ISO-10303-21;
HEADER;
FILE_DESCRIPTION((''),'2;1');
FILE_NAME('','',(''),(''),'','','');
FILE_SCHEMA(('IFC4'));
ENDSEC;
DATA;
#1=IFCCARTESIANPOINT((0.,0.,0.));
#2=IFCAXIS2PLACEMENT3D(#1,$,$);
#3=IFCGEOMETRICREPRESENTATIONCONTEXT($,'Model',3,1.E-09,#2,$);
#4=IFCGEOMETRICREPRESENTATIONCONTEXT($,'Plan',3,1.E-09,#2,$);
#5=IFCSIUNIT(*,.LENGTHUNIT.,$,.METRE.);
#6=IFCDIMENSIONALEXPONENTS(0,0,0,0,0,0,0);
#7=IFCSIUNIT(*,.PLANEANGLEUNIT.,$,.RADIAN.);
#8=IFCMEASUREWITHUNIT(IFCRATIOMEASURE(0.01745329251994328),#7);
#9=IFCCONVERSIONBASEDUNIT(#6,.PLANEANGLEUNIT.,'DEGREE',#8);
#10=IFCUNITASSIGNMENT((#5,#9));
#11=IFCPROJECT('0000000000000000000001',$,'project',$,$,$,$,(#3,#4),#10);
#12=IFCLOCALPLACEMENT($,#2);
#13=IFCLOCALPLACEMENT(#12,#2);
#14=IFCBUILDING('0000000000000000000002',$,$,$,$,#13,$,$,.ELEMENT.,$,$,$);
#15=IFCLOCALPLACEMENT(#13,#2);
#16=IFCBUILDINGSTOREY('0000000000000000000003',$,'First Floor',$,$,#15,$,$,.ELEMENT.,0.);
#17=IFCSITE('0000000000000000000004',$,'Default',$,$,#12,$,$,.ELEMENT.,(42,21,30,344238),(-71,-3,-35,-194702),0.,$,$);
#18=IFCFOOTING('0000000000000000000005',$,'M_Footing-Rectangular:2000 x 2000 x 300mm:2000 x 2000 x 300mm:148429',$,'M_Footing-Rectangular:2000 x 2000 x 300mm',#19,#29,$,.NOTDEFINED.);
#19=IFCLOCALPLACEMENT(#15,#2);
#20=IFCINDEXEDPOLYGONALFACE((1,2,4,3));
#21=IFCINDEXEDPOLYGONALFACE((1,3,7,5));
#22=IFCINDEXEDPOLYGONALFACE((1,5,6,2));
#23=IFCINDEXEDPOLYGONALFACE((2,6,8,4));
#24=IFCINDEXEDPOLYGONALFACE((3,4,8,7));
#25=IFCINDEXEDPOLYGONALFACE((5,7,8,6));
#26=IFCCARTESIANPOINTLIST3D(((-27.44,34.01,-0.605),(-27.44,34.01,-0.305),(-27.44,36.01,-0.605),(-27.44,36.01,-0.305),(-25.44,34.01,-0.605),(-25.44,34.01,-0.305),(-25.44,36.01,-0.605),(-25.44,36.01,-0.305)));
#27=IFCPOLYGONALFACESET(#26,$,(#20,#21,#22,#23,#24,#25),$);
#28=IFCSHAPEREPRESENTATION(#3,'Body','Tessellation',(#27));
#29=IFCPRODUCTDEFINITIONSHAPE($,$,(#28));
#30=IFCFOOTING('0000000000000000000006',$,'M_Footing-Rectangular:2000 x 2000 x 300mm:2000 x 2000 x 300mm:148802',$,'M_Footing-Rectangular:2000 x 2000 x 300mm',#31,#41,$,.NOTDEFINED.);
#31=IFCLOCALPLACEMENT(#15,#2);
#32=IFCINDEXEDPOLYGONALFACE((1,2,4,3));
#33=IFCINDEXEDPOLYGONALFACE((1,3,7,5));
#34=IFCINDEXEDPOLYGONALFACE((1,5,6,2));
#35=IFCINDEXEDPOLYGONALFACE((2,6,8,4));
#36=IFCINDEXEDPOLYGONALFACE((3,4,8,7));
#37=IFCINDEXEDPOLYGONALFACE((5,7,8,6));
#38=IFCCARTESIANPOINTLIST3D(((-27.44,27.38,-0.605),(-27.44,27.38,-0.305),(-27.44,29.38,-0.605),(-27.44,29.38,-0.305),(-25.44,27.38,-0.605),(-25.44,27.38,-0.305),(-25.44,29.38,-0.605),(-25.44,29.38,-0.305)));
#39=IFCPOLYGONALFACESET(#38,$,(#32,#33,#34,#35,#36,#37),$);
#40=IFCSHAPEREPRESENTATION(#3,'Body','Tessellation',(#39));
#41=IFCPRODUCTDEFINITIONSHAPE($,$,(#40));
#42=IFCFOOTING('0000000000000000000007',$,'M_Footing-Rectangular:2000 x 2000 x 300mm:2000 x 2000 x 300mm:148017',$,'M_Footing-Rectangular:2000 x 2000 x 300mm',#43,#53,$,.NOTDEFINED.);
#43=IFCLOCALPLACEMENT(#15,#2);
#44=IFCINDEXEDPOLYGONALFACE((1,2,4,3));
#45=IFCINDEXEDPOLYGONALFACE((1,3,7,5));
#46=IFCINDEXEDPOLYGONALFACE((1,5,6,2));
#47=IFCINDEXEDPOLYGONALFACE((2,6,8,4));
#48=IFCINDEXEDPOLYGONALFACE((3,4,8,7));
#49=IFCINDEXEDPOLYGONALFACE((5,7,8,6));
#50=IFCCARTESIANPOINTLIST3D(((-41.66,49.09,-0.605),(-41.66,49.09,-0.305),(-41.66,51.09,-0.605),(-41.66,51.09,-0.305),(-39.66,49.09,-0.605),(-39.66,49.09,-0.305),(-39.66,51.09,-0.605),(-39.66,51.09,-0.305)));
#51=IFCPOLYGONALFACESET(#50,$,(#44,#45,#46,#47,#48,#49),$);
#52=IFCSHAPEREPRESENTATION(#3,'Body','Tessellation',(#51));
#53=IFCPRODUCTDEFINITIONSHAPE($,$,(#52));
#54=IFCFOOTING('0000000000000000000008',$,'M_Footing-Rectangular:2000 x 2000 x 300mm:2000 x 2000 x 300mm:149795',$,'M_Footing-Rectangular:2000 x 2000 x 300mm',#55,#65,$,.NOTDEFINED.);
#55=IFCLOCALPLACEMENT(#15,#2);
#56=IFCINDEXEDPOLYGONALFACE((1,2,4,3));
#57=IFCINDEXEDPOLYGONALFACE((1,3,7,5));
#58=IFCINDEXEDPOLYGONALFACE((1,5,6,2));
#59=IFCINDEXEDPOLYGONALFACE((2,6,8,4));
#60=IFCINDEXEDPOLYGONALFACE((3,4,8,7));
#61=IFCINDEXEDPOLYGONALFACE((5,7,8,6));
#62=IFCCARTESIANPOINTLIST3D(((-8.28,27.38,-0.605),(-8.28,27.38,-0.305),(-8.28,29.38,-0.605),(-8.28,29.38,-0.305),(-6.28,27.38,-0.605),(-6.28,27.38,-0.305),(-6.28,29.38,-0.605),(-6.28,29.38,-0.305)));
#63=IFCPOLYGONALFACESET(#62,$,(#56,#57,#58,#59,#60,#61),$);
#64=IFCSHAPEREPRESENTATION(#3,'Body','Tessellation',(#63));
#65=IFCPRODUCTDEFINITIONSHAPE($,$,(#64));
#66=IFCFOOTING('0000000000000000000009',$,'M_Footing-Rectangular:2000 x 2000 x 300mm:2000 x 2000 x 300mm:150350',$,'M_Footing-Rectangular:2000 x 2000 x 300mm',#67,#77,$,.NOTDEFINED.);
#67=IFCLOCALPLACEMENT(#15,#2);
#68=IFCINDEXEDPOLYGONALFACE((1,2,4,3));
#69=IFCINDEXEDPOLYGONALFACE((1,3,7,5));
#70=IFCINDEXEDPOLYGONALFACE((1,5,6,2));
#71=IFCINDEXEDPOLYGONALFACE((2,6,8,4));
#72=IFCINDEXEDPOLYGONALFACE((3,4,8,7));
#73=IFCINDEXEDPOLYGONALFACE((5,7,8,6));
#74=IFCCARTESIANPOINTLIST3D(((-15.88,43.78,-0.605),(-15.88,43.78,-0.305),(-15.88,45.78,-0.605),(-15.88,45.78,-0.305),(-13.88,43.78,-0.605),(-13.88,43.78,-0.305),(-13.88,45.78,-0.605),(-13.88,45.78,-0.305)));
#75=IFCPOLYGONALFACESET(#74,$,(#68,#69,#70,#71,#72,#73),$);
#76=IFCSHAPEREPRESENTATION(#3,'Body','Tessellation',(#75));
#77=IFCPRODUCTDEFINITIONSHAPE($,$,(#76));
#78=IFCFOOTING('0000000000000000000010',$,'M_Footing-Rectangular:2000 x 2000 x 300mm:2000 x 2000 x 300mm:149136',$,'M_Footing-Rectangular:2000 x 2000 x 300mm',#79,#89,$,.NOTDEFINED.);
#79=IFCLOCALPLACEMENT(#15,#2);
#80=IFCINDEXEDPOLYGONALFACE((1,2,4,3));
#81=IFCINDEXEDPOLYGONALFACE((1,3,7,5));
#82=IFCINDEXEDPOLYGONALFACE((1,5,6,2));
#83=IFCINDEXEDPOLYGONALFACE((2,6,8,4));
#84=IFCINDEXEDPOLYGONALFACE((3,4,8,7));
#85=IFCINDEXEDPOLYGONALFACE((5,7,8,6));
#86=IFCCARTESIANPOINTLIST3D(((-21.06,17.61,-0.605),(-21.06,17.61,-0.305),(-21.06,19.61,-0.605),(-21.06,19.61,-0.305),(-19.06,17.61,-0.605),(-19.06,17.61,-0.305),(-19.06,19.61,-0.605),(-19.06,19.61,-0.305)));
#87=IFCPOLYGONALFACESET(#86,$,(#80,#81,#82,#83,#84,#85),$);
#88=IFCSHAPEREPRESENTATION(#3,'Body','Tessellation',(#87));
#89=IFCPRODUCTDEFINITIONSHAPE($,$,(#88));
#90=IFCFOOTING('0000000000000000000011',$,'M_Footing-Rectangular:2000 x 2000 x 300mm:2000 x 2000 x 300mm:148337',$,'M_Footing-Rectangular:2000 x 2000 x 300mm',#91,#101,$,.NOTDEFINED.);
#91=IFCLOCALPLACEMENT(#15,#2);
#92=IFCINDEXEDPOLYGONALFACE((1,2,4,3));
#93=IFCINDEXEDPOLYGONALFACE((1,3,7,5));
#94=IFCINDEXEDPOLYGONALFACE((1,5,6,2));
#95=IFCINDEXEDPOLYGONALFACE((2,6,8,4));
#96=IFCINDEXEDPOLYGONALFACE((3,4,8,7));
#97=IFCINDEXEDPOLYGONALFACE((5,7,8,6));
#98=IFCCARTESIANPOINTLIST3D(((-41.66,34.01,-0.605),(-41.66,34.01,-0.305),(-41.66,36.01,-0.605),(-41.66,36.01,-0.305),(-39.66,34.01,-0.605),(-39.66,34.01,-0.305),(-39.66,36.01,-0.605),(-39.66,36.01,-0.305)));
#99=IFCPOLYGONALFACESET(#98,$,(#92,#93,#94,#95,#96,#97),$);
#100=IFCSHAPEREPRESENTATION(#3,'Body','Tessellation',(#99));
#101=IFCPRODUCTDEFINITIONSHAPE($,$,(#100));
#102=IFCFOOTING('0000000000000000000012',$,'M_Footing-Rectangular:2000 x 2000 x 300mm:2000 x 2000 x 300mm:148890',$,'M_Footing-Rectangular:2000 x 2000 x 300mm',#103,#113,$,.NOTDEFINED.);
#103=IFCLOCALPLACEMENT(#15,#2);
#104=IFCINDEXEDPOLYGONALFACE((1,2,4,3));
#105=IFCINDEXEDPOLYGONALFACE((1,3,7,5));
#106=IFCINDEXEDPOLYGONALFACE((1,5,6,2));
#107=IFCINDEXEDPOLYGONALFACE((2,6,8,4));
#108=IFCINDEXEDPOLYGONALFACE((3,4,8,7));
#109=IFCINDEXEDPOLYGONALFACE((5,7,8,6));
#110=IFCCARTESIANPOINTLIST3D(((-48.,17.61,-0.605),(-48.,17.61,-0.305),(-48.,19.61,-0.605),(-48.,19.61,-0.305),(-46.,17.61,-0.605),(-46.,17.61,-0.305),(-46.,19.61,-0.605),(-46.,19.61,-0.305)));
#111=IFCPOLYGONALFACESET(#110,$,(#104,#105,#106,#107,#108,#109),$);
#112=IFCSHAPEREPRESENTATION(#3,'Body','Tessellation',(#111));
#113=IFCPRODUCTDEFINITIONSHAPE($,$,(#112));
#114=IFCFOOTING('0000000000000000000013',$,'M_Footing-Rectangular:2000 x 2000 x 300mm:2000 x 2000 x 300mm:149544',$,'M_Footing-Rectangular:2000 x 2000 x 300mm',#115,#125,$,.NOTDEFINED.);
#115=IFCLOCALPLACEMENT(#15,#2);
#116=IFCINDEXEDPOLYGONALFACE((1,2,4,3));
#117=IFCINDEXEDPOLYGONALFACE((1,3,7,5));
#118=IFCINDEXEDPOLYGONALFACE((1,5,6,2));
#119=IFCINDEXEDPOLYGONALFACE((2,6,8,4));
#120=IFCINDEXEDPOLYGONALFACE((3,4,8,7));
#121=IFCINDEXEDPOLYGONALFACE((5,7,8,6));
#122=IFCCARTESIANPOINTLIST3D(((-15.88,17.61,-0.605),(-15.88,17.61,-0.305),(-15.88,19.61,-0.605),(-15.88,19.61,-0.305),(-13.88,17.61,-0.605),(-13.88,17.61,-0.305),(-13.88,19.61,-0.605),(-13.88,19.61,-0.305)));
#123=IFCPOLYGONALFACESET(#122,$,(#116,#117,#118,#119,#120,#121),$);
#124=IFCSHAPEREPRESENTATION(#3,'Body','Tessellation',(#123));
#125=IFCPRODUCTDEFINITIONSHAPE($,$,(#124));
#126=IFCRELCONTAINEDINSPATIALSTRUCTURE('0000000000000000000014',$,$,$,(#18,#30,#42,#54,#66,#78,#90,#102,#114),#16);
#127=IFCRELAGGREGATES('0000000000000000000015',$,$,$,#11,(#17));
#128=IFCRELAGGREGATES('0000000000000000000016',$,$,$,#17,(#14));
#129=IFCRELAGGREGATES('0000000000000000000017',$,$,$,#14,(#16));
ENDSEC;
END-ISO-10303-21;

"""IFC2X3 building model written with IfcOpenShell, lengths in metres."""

from ifc_helpers import new_model, entity, si_unit, converted_unit, frame, origin, origin_2d_with_axis, place, context, project, spatial, rectangle, extrude, element, save


model = new_model("IFC2X3")

# Units and contexts
model_context = context("Model", 3, precision=1e-09, world=origin())
plan_context = context("Plan", 3, precision=1e-09, world=origin())
ifc_project = project(units=[si_unit("LENGTHUNIT", "METRE"), converted_unit("PLANEANGLEUNIT", "DEGREE", entity("IfcRatioMeasure", 0.01745329251994328), si_unit("PLANEANGLEUNIT", "RADIAN"), dimensions=[0, 0, 0, 0, 0, 0, 0])], contexts=[model_context, plan_context])

# Site, building, storey
site_placement = place(None, origin())
site = spatial("IfcSite", under=ifc_project, at=site_placement, Name="Default", CompositionType="ELEMENT", RefLatitude=(42, 21, 30, 344238), RefLongitude=(-71, -3, -35, -194702), RefElevation=0.0)
building_placement = place(site_placement, origin())
building = spatial("IfcBuilding", under=site, at=building_placement, CompositionType="ELEMENT")
storey_placement = place(building_placement, origin())
storey = spatial("IfcBuildingStorey", under=building, at=storey_placement, Name="First Floor", CompositionType="ELEMENT", Elevation=0.0)

# Footings
footing_1_placement = place(storey_placement, origin())
element("IfcFooting", 1, at=footing_1_placement, inside=storey, Name="M_Footing-Rectangular:2000 x 2000 x 300mm:2000 x 2000 x 300mm:148429", ObjectType="M_Footing-Rectangular:2000 x 2000 x 300mm", PredefinedType="NOTDEFINED", context=model_context, shape_type="SweptSolid", body=[
    extrude(rectangle(XDim=2.0, YDim=2.0, at=origin_2d_with_axis()), frame((-26.44, 35.01, -0.605), z_axis=(0.0, 0.0, 1.0), x_axis=(-1.0, 0.0, 0.0)), (0.0, 0.0, 1.0), 0.3),
])
footing_2_placement = place(storey_placement, origin())
element("IfcFooting", 2, at=footing_2_placement, inside=storey, Name="M_Footing-Rectangular:2000 x 2000 x 300mm:2000 x 2000 x 300mm:148802", ObjectType="M_Footing-Rectangular:2000 x 2000 x 300mm", PredefinedType="NOTDEFINED", context=model_context, shape_type="SweptSolid", body=[
    extrude(rectangle(XDim=2.0, YDim=2.0, at=origin_2d_with_axis()), frame((-26.44, 28.38, -0.605), z_axis=(0.0, 0.0, 1.0), x_axis=(-1.0, 0.0, 0.0)), (0.0, 0.0, 1.0), 0.3),
])
footing_3_placement = place(storey_placement, origin())
element("IfcFooting", 3, at=footing_3_placement, inside=storey, Name="M_Footing-Rectangular:2000 x 2000 x 300mm:2000 x 2000 x 300mm:148017", ObjectType="M_Footing-Rectangular:2000 x 2000 x 300mm", PredefinedType="NOTDEFINED", context=model_context, shape_type="SweptSolid", body=[
    extrude(rectangle(XDim=2.0, YDim=2.0, at=origin_2d_with_axis()), frame((-40.66, 50.09, -0.605), z_axis=(0.0, 0.0, 1.0), x_axis=(-1.0, 0.0, 0.0)), (0.0, 0.0, 1.0), 0.3),
])
footing_4_placement = place(storey_placement, origin())
element("IfcFooting", 4, at=footing_4_placement, inside=storey, Name="M_Footing-Rectangular:2000 x 2000 x 300mm:2000 x 2000 x 300mm:149795", ObjectType="M_Footing-Rectangular:2000 x 2000 x 300mm", PredefinedType="NOTDEFINED", context=model_context, shape_type="SweptSolid", body=[
    extrude(rectangle(XDim=2.0, YDim=2.0, at=origin_2d_with_axis()), frame((-7.28, 28.38, -0.605), z_axis=(0.0, 0.0, 1.0), x_axis=(-1.0, 0.0, 0.0)), (0.0, 0.0, 1.0), 0.3),
])
footing_5_placement = place(storey_placement, origin())
element("IfcFooting", 5, at=footing_5_placement, inside=storey, Name="M_Footing-Rectangular:2000 x 2000 x 300mm:2000 x 2000 x 300mm:150350", ObjectType="M_Footing-Rectangular:2000 x 2000 x 300mm", PredefinedType="NOTDEFINED", context=model_context, shape_type="SweptSolid", body=[
    extrude(rectangle(XDim=2.0, YDim=2.0, at=origin_2d_with_axis()), frame((-14.88, 44.78, -0.605), z_axis=(0.0, 0.0, 1.0), x_axis=(-1.0, 0.0, 0.0)), (0.0, 0.0, 1.0), 0.3),
])
footing_6_placement = place(storey_placement, origin())
element("IfcFooting", 6, at=footing_6_placement, inside=storey, Name="M_Footing-Rectangular:2000 x 2000 x 300mm:2000 x 2000 x 300mm:149136", ObjectType="M_Footing-Rectangular:2000 x 2000 x 300mm", PredefinedType="NOTDEFINED", context=model_context, shape_type="SweptSolid", body=[
    extrude(rectangle(XDim=2.0, YDim=2.0, at=origin_2d_with_axis()), frame((-20.06, 18.61, -0.605), z_axis=(0.0, 0.0, 1.0), x_axis=(-1.0, 0.0, 0.0)), (0.0, 0.0, 1.0), 0.3),
])
footing_7_placement = place(storey_placement, origin())
element("IfcFooting", 7, at=footing_7_placement, inside=storey, Name="M_Footing-Rectangular:2000 x 2000 x 300mm:2000 x 2000 x 300mm:148337", ObjectType="M_Footing-Rectangular:2000 x 2000 x 300mm", PredefinedType="NOTDEFINED", context=model_context, shape_type="SweptSolid", body=[
    extrude(rectangle(XDim=2.0, YDim=2.0, at=origin_2d_with_axis()), frame((-40.66, 35.01, -0.605), z_axis=(0.0, 0.0, 1.0), x_axis=(-1.0, 0.0, 0.0)), (0.0, 0.0, 1.0), 0.3),
])
footing_8_placement = place(storey_placement, origin())
element("IfcFooting", 8, at=footing_8_placement, inside=storey, Name="M_Footing-Rectangular:2000 x 2000 x 300mm:2000 x 2000 x 300mm:148890", ObjectType="M_Footing-Rectangular:2000 x 2000 x 300mm", PredefinedType="NOTDEFINED", context=model_context, shape_type="SweptSolid", body=[
    extrude(rectangle(XDim=2.0, YDim=2.0, at=origin_2d_with_axis()), frame((-47.0, 18.61, -0.605), z_axis=(0.0, 0.0, 1.0), x_axis=(-1.0, 0.0, 0.0)), (0.0, 0.0, 1.0), 0.3),
])
footing_9_placement = place(storey_placement, origin())
element("IfcFooting", 9, at=footing_9_placement, inside=storey, Name="M_Footing-Rectangular:2000 x 2000 x 300mm:2000 x 2000 x 300mm:149544", ObjectType="M_Footing-Rectangular:2000 x 2000 x 300mm", PredefinedType="NOTDEFINED", context=model_context, shape_type="SweptSolid", body=[
    extrude(rectangle(XDim=2.0, YDim=2.0, at=origin_2d_with_axis()), frame((-14.88, 18.61, -0.605), z_axis=(0.0, 0.0, 1.0), x_axis=(-1.0, 0.0, 0.0)), (0.0, 0.0, 1.0), 0.3),
])

save(model, "model.ifc")
